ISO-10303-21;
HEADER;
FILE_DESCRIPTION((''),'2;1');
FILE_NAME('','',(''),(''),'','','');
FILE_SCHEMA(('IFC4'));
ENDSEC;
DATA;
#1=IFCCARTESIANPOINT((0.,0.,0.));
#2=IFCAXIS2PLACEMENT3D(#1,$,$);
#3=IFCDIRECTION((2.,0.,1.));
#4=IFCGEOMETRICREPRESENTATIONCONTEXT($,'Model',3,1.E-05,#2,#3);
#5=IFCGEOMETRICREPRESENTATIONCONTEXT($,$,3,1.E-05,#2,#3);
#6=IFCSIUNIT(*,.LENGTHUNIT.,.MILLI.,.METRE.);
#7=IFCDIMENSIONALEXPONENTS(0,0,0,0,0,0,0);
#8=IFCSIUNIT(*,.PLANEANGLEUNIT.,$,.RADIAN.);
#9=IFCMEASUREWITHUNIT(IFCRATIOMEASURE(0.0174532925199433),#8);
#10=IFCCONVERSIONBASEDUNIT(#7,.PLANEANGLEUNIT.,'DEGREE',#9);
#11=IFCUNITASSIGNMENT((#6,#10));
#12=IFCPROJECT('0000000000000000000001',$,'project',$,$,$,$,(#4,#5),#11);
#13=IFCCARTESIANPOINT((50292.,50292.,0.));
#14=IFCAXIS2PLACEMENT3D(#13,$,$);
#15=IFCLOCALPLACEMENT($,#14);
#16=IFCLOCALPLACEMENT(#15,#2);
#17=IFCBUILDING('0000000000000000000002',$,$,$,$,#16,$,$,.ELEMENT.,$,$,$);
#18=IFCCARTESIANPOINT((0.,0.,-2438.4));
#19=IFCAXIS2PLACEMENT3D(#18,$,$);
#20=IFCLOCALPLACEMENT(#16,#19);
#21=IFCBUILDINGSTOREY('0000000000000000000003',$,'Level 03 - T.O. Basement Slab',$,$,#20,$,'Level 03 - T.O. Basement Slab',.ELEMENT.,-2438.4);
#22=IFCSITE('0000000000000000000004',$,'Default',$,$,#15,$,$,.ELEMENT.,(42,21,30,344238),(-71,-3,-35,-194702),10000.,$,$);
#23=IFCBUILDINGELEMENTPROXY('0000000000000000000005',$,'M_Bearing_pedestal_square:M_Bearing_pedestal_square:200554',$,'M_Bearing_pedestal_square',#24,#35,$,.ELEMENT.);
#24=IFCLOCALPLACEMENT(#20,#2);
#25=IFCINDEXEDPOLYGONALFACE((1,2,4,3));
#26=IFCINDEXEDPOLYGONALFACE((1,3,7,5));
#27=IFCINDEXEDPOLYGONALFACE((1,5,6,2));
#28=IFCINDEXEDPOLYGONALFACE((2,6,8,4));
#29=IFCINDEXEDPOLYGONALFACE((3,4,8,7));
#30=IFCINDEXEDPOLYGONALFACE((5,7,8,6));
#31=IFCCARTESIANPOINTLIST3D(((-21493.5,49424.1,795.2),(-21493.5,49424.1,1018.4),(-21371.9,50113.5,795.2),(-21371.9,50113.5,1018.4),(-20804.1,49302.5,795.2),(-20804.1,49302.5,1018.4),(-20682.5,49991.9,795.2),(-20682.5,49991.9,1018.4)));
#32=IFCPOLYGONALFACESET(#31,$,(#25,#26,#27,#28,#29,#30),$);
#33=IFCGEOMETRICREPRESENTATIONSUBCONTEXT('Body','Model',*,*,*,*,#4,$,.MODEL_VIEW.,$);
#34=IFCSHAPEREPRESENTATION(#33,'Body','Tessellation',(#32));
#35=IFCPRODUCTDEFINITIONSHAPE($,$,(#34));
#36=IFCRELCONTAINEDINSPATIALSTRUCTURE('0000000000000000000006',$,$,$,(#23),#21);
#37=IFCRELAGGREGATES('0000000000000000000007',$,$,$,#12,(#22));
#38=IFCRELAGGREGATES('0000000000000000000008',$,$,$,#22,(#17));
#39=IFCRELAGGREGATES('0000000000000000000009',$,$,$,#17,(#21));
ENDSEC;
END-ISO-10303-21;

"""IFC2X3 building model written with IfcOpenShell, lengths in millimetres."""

from ifc_helpers import new_model, entity, si_unit, converted_unit, direction, frame, origin, origin_2d_with_axis, place, context, subcontext, project, spatial, rectangle, extrude, source, transform, mapped, element, save


model = new_model("IFC2X3")

# Units and contexts
model_context = context("Model", 3, precision=1e-05, world=origin(), true_north=direction((2.0, 0.0, 1.0)))
context_of_model = context(None, 3, precision=1e-05, world=origin(), true_north=direction((2.0, 0.0, 1.0)))
body_context = subcontext(model_context, "Body", "Model", "MODEL_VIEW")
ifc_project = project(units=[si_unit("LENGTHUNIT", "METRE", prefix="MILLI"), converted_unit("PLANEANGLEUNIT", "DEGREE", entity("IfcRatioMeasure", 0.0174532925199433), si_unit("PLANEANGLEUNIT", "RADIAN"), dimensions=[0, 0, 0, 0, 0, 0, 0])], contexts=[model_context, context_of_model])

# Site, building, storey
site_placement = place(None, frame((50292.0, 50292.0, 0.0)))
site = spatial("IfcSite", under=ifc_project, at=site_placement, Name="Default", CompositionType="ELEMENT", RefLatitude=(42, 21, 30, 344238), RefLongitude=(-71, -3, -35, -194702), RefElevation=10000.0)
building_placement = place(site_placement, origin())
building = spatial("IfcBuilding", under=site, at=building_placement, CompositionType="ELEMENT")
storey_placement = place(building_placement, frame((0.0, 0.0, -2438.4)))
storey = spatial("IfcBuildingStorey", under=building, at=storey_placement, Name="Level 03 - T.O. Basement Slab", LongName="Level 03 - T.O. Basement Slab", CompositionType="ELEMENT", Elevation=-2438.4)

# Building element proxy
shared_shape_1 = source(origin(), body_context, "Body", "SweptSolid", [
    extrude(rectangle(XDim=700.0, YDim=700.0, at=origin_2d_with_axis()), frame((0.0, 0.0, -223.2)), (0.0, 0.0, 1.0), 223.2),
])
proxy_1_placement = place(storey_placement, frame((-21088.0, 49708.0, 1018.4), z_axis=(0.0, 0.0, 1.0), x_axis=(0.173648, 0.984808, 0.0)))
element("IfcBuildingElementProxy", 1, at=proxy_1_placement, inside=storey, Name="M_Bearing_pedestal_square:M_Bearing_pedestal_square:200554", ObjectType="M_Bearing_pedestal_square", CompositionType="ELEMENT", context=body_context, shape_type="MappedRepresentation", body=[
    mapped(shared_shape_1, transform((0.0, 0.0, 0.0), scale=1.0)),
])

save(model, "model.ifc")
